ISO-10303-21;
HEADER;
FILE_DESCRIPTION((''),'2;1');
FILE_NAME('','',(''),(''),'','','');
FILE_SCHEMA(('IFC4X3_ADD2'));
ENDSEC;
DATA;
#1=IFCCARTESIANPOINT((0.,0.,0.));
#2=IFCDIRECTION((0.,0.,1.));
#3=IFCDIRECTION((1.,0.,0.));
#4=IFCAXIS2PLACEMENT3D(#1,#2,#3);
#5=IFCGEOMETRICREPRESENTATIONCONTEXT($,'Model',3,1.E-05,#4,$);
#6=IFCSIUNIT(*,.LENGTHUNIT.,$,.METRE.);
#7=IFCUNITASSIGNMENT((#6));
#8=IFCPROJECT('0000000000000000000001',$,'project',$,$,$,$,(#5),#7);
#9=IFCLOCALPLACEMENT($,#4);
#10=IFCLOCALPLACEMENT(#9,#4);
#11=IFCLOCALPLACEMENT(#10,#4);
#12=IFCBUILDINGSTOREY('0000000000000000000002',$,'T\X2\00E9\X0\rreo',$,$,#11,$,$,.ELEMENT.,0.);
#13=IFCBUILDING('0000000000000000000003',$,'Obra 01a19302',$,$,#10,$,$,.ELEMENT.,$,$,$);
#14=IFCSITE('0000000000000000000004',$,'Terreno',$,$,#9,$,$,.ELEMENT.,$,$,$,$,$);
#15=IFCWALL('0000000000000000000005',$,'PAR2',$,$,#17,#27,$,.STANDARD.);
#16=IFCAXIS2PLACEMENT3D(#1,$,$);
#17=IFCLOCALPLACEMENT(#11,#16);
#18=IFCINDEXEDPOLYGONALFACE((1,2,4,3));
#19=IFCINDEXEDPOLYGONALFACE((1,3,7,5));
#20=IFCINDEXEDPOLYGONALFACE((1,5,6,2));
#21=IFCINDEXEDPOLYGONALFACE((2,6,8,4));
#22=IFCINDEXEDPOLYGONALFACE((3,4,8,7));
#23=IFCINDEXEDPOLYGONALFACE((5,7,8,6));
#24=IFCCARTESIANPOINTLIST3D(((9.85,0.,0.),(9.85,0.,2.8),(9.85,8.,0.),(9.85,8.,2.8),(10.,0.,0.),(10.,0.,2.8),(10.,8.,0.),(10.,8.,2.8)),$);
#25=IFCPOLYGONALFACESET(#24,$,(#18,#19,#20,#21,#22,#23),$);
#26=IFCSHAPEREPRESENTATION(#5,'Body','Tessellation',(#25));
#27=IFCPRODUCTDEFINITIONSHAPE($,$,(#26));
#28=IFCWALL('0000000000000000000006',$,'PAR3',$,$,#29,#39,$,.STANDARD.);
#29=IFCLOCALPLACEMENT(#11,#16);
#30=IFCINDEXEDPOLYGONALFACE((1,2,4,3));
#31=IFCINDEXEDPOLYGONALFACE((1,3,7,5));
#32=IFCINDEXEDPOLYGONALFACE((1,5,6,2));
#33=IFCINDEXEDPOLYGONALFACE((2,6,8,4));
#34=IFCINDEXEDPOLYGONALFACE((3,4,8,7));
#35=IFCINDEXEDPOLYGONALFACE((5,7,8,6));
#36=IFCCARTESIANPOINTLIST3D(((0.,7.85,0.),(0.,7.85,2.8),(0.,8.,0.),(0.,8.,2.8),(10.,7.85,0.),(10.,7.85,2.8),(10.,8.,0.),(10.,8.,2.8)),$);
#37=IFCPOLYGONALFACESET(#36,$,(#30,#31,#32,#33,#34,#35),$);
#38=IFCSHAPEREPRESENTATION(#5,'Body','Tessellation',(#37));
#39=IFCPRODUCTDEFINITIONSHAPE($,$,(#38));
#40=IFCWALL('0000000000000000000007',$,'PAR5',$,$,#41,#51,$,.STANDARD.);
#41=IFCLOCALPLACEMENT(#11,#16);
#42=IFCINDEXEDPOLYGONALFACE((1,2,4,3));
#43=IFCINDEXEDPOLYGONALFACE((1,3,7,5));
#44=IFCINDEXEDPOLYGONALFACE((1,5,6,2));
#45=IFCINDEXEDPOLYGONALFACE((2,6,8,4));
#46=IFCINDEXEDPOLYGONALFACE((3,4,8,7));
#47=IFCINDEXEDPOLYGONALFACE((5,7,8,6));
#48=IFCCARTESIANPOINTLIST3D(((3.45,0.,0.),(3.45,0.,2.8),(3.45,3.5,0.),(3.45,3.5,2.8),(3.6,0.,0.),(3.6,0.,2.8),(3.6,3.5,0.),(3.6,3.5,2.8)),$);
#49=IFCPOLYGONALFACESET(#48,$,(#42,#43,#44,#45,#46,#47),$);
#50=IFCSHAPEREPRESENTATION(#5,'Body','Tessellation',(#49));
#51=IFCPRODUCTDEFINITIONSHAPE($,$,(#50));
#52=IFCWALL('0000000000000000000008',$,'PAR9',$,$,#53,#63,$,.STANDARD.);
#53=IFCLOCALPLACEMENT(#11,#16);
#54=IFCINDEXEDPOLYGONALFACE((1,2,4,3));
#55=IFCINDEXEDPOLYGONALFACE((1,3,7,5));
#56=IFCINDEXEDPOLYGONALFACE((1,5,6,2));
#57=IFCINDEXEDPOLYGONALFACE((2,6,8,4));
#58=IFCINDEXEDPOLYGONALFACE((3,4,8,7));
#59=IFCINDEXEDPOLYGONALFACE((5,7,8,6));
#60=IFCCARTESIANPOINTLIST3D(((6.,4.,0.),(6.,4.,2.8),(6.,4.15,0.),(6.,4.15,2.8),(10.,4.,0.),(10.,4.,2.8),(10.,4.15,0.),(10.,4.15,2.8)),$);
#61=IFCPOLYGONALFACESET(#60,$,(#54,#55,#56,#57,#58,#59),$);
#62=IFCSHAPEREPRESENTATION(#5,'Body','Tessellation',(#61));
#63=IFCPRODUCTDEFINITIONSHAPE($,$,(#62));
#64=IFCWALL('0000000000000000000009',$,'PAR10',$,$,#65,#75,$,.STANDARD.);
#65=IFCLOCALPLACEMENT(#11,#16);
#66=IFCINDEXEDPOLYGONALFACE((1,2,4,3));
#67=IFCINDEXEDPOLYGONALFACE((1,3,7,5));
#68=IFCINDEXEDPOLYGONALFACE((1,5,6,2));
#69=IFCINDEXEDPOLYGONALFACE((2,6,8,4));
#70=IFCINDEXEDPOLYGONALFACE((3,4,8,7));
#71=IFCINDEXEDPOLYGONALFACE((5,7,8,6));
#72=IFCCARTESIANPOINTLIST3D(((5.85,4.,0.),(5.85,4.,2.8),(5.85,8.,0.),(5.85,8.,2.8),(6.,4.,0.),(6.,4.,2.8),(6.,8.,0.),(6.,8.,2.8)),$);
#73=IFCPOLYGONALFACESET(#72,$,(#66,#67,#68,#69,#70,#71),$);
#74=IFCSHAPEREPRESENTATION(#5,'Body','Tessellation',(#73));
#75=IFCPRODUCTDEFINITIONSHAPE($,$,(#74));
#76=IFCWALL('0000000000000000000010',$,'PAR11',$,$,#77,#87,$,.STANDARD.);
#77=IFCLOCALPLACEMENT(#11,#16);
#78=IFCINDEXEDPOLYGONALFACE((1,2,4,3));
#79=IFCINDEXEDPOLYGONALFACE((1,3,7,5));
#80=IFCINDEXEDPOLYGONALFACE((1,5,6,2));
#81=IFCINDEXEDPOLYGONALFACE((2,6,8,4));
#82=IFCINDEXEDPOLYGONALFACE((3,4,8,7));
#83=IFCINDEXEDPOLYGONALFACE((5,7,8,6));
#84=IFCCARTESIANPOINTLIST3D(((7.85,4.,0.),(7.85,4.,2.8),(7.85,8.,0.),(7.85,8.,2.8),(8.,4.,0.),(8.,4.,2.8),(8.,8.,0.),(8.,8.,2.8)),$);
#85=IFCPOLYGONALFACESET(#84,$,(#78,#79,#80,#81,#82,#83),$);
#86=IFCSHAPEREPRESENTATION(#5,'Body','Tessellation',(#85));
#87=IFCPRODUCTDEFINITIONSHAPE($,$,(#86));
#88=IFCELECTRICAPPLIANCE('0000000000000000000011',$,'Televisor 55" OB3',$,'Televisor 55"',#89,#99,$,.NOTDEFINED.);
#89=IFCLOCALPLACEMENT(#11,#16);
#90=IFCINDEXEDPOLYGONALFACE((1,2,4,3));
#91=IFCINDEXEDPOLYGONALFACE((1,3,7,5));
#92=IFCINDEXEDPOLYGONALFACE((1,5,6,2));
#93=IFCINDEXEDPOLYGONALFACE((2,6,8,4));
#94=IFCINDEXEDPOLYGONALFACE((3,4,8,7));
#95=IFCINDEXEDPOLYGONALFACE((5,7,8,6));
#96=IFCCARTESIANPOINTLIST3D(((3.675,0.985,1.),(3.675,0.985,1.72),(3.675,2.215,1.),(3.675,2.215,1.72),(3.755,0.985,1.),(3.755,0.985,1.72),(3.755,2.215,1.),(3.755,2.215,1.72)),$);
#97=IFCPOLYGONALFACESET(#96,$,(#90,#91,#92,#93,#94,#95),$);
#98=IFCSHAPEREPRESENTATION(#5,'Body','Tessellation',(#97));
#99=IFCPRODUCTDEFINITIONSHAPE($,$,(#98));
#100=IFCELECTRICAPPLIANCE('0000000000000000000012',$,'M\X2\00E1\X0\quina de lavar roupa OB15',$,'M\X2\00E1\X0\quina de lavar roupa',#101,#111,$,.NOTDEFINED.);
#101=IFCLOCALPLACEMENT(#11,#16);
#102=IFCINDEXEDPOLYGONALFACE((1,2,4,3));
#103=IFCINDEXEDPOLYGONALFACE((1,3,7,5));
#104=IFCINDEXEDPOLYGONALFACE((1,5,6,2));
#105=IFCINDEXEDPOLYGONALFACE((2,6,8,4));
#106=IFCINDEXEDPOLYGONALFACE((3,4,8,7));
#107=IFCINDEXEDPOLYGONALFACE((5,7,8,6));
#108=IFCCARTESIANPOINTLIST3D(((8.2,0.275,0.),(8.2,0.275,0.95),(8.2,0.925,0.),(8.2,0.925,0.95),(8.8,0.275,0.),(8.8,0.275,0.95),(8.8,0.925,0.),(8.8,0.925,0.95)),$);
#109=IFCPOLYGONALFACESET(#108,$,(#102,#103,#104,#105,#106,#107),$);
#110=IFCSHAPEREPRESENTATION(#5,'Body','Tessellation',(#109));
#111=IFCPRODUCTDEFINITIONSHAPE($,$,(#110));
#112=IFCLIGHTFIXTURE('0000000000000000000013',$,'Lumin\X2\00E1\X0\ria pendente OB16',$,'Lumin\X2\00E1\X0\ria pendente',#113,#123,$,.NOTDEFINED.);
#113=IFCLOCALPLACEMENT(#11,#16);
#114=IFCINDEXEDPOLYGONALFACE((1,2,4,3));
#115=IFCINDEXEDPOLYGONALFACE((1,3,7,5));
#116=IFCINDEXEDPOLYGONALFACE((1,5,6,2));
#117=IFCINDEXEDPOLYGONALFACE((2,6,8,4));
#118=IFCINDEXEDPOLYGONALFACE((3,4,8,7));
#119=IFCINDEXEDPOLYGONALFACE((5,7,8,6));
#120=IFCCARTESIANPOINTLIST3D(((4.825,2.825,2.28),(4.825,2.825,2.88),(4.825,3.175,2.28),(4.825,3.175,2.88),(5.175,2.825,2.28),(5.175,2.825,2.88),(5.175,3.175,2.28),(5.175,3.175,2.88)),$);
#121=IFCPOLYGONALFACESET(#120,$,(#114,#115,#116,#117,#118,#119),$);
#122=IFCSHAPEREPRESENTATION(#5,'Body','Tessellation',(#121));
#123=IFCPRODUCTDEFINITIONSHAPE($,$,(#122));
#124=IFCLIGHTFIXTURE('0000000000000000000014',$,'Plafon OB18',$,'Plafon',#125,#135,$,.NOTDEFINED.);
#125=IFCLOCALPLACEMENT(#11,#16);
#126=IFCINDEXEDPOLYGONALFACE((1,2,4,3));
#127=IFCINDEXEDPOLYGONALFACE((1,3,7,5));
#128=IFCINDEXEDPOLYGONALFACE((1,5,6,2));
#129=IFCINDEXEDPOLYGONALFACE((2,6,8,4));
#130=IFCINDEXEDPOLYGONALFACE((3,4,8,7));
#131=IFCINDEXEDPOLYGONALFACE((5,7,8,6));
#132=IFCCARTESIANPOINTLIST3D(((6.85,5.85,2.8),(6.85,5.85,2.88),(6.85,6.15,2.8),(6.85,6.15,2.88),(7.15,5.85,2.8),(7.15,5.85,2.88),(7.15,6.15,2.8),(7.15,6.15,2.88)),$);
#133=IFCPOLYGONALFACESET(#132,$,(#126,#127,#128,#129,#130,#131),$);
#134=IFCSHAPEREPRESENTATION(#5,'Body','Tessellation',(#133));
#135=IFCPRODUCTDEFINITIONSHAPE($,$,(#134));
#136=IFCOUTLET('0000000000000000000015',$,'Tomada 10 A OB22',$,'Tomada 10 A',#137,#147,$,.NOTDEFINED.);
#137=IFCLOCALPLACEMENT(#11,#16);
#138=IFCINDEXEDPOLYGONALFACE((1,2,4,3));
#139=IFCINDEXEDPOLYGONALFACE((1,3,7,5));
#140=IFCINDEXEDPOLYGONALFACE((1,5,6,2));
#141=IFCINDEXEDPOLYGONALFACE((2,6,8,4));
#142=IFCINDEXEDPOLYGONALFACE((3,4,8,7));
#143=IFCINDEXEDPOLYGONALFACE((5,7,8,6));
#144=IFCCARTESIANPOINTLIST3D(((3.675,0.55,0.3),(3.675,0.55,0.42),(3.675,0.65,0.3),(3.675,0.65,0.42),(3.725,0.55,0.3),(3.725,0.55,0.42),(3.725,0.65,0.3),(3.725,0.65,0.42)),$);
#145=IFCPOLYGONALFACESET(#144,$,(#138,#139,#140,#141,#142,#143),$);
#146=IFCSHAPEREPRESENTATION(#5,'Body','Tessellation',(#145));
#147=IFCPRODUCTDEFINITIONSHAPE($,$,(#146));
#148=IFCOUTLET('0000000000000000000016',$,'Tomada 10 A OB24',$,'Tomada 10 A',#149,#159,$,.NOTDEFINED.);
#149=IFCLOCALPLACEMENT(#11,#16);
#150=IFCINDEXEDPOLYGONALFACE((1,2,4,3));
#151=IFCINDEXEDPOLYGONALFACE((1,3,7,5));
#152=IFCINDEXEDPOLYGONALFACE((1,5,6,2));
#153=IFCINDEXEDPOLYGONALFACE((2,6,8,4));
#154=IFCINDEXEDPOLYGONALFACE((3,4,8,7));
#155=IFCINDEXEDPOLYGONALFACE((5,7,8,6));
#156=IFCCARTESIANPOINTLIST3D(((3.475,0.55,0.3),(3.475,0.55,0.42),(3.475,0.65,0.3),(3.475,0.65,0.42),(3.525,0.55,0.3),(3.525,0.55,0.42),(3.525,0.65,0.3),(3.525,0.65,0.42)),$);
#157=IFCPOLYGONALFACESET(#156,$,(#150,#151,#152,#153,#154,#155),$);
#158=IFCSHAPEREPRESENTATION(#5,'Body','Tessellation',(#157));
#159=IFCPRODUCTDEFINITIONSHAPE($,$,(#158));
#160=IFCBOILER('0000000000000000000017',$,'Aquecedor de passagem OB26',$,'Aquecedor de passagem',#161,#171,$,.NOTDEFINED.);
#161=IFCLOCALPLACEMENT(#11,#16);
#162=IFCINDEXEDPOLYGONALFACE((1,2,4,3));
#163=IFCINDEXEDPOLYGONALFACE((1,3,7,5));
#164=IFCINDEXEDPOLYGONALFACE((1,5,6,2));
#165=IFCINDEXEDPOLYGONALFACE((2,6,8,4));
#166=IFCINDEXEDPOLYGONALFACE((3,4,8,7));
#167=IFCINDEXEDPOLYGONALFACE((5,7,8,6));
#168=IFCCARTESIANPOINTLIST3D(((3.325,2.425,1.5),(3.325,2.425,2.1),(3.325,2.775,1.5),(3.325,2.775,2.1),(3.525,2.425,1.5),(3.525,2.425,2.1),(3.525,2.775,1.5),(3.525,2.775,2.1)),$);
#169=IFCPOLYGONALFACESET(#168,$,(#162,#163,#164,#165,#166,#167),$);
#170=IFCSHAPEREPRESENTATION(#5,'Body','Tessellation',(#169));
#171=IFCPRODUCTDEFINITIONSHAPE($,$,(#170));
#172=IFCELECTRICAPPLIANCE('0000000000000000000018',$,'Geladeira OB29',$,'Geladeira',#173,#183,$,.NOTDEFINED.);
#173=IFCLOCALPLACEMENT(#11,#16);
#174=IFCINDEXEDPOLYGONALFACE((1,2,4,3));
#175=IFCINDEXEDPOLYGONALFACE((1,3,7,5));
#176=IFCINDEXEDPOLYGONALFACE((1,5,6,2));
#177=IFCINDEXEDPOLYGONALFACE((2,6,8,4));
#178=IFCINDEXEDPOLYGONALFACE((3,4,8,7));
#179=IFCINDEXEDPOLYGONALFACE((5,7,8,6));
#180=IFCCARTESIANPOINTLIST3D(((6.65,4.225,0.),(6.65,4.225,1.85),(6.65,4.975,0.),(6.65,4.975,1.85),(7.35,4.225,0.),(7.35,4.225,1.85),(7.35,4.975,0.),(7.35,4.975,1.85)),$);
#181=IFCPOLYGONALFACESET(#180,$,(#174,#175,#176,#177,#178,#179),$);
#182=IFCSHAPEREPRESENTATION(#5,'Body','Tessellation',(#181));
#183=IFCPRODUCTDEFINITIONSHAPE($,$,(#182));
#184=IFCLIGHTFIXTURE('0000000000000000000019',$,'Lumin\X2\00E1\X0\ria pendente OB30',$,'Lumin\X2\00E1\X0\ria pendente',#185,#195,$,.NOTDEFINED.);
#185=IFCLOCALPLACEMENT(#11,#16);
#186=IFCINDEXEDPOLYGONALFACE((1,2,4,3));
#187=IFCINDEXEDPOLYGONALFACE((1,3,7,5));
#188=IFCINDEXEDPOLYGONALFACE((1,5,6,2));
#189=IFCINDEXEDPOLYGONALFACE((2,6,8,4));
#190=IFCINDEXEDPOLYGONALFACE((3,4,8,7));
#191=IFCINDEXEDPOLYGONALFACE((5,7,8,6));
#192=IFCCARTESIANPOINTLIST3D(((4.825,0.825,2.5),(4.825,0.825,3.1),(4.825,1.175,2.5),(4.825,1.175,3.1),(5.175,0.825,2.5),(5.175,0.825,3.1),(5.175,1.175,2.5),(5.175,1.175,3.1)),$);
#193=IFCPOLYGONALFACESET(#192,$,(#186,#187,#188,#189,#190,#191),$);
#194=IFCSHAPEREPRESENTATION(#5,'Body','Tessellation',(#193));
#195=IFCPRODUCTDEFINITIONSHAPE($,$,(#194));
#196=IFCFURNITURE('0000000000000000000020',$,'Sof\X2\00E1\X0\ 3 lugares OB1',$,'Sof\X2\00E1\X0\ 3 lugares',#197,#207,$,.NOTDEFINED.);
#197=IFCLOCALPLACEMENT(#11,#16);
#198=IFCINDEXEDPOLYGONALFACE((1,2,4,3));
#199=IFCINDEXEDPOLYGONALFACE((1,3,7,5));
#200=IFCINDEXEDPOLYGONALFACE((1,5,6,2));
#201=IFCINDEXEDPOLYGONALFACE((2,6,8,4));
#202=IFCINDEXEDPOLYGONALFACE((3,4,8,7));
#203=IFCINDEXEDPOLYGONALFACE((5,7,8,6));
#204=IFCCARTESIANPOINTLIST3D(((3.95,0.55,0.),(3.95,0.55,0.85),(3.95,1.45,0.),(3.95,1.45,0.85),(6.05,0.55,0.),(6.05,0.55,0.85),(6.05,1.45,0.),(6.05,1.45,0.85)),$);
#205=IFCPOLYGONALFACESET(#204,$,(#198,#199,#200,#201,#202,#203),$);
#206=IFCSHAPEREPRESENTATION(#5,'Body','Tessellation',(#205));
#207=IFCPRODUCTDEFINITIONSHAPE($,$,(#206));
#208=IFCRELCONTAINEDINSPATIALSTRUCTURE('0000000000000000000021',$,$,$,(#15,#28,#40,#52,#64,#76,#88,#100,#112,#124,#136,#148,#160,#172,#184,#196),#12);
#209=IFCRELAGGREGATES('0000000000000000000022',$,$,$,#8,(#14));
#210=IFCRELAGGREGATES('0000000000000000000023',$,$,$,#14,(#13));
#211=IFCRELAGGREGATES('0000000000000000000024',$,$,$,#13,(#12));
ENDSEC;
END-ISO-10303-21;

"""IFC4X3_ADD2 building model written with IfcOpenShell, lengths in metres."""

from ifc_helpers import new_model, si_unit, frame, frame_2d, origin_with_axes, place, context, project, spatial, rectangle, extrude, element, save


model = new_model("IFC4X3_ADD2")

# Units and contexts
model_context = context("Model", 3, precision=1e-05, world=origin_with_axes())
ifc_project = project(units=[si_unit("LENGTHUNIT", "METRE")], contexts=[model_context])

# Site, building, storey
site_placement = place(None, origin_with_axes())
site = spatial("IfcSite", under=ifc_project, at=site_placement, Name="Terreno", CompositionType="ELEMENT")
building_placement = place(site_placement, origin_with_axes())
building = spatial("IfcBuilding", under=site, at=building_placement, Name="Obra 01a19302", CompositionType="ELEMENT")
storey_placement = place(building_placement, origin_with_axes())
storey = spatial("IfcBuildingStorey", under=building, at=storey_placement, Name="Térreo", CompositionType="ELEMENT", Elevation=0.0)

# Walls
wall_1_placement = place(storey_placement, frame((10.0, 0.0, 0.0), z_axis=(0.0, 0.0, 1.0), x_axis=(0.0, 1.0, 0.0)))
element("IfcWall", 1, at=wall_1_placement, inside=storey, Name="PAR2", PredefinedType="STANDARD", context=model_context, shape_type="SweptSolid", body=[
    extrude(rectangle(XDim=8.0, YDim=0.15, at=frame_2d((4.0, 0.075))), origin_with_axes(), (0.0, 0.0, 1.0), 2.8),
])
wall_2_placement = place(storey_placement, frame((10.0, 8.0, 0.0), z_axis=(0.0, 0.0, 1.0), x_axis=(-1.0, 0.0, 0.0)))
element("IfcWall", 2, at=wall_2_placement, inside=storey, Name="PAR3", PredefinedType="STANDARD", context=model_context, shape_type="SweptSolid", body=[
    extrude(rectangle(XDim=10.0, YDim=0.15, at=frame_2d((5.0, 0.075))), origin_with_axes(), (0.0, 0.0, 1.0), 2.8),
])
wall_3_placement = place(storey_placement, frame((3.6, 0.0, 0.0), z_axis=(0.0, 0.0, 1.0), x_axis=(0.0, 1.0, 0.0)))
element("IfcWall", 3, at=wall_3_placement, inside=storey, Name="PAR5", PredefinedType="STANDARD", context=model_context, shape_type="SweptSolid", body=[
    extrude(rectangle(XDim=3.5, YDim=0.15, at=frame_2d((1.75, 0.075))), origin_with_axes(), (0.0, 0.0, 1.0), 2.8),
])
for number, where, z_axis, x_axis, name in (
    (4, (6.0, 4.0, 0.0), (0.0, 0.0, 1.0), (1.0, 0.0, 0.0), "PAR9"),
    (5, (6.0, 4.0, 0.0), (0.0, 0.0, 1.0), (0.0, 1.0, 0.0), "PAR10"),
    (6, (8.0, 4.0, 0.0), (0.0, 0.0, 1.0), (0.0, 1.0, 0.0), "PAR11"),
):
    element("IfcWall", number, at=place(storey_placement, frame(where, z_axis=z_axis, x_axis=x_axis)), inside=storey, Name=name, PredefinedType="STANDARD", context=model_context, shape_type="SweptSolid", body=[
        extrude(rectangle(XDim=4.0, YDim=0.15, at=frame_2d((2.0, 0.075))), origin_with_axes(), (0.0, 0.0, 1.0), 2.8),
    ])

# Electric appliances
electric_appliance_1_placement = place(storey_placement, frame((3.675, 2.215, 1.0), z_axis=(0.0, 0.0, 1.0), x_axis=(0.0, -1.0, 0.0)))
element("IfcElectricAppliance", 7, at=electric_appliance_1_placement, inside=storey, Name="Televisor 55\" OB3", ObjectType="Televisor 55\"", PredefinedType="NOTDEFINED", context=model_context, shape_type="SweptSolid", body=[
    extrude(rectangle(XDim=1.23, YDim=0.08, at=frame_2d((0.615, 0.04))), origin_with_axes(), (0.0, 0.0, 1.0), 0.72),
])
electric_appliance_2_placement = place(storey_placement, frame((8.2, 0.275, 0.0), z_axis=(0.0, 0.0, 1.0), x_axis=(1.0, 0.0, 0.0)))
element("IfcElectricAppliance", 8, at=electric_appliance_2_placement, inside=storey, Name="Máquina de lavar roupa OB15", ObjectType="Máquina de lavar roupa", PredefinedType="NOTDEFINED", context=model_context, shape_type="SweptSolid", body=[
    extrude(rectangle(XDim=0.6, YDim=0.65, at=frame_2d((0.3, 0.325))), origin_with_axes(), (0.0, 0.0, 1.0), 0.95),
])

# Light fixtures
light_fixture_1_placement = place(storey_placement, frame((4.825, 2.825, 2.28), z_axis=(0.0, 0.0, 1.0), x_axis=(1.0, 0.0, 0.0)))
element("IfcLightFixture", 9, at=light_fixture_1_placement, inside=storey, Name="Luminária pendente OB16", ObjectType="Luminária pendente", PredefinedType="NOTDEFINED", context=model_context, shape_type="SweptSolid", body=[
    extrude(rectangle(XDim=0.35, YDim=0.35, at=frame_2d((0.175, 0.175))), origin_with_axes(), (0.0, 0.0, 1.0), 0.6),
])
light_fixture_2_placement = place(storey_placement, frame((6.85, 5.85, 2.8), z_axis=(0.0, 0.0, 1.0), x_axis=(1.0, 0.0, 0.0)))
element("IfcLightFixture", 10, at=light_fixture_2_placement, inside=storey, Name="Plafon OB18", ObjectType="Plafon", PredefinedType="NOTDEFINED", context=model_context, shape_type="SweptSolid", body=[
    extrude(rectangle(XDim=0.3, YDim=0.3, at=frame_2d((0.15, 0.15))), origin_with_axes(), (0.0, 0.0, 1.0), 0.08),
])

# Outlets
for number, where, z_axis, x_axis, name in (
    (11, (3.675, 0.65, 0.3), (0.0, 0.0, 1.0), (0.0, -1.0, 0.0), "Tomada 10 A OB22"),
    (12, (3.525, 0.55, 0.3), (0.0, 0.0, 1.0), (0.0, 1.0, 0.0), "Tomada 10 A OB24"),
):
    element("IfcOutlet", number, at=place(storey_placement, frame(where, z_axis=z_axis, x_axis=x_axis)), inside=storey, Name=name, ObjectType="Tomada 10 A", PredefinedType="NOTDEFINED", context=model_context, shape_type="SweptSolid", body=[
        extrude(rectangle(XDim=0.1, YDim=0.05, at=frame_2d((0.05, 0.025))), origin_with_axes(), (0.0, 0.0, 1.0), 0.12),
    ])

# Boiler
boiler_placement = place(storey_placement, frame((3.525, 2.425, 1.5), z_axis=(0.0, 0.0, 1.0), x_axis=(0.0, 1.0, 0.0)))
element("IfcBoiler", 13, at=boiler_placement, inside=storey, Name="Aquecedor de passagem OB26", ObjectType="Aquecedor de passagem", PredefinedType="NOTDEFINED", context=model_context, shape_type="SweptSolid", body=[
    extrude(rectangle(XDim=0.35, YDim=0.2, at=frame_2d((0.175, 0.1))), origin_with_axes(), (0.0, 0.0, 1.0), 0.6),
])

# Electric appliance
electric_appliance_3_placement = place(storey_placement, frame((6.65, 4.225, 0.0), z_axis=(0.0, 0.0, 1.0), x_axis=(1.0, 0.0, 0.0)))
element("IfcElectricAppliance", 14, at=electric_appliance_3_placement, inside=storey, Name="Geladeira OB29", ObjectType="Geladeira", PredefinedType="NOTDEFINED", context=model_context, shape_type="SweptSolid", body=[
    extrude(rectangle(XDim=0.7, YDim=0.75, at=frame_2d((0.35, 0.375))), origin_with_axes(), (0.0, 0.0, 1.0), 1.85),
])

# Light fixture
light_fixture_3_placement = place(storey_placement, frame((4.825, 0.825, 2.5), z_axis=(0.0, 0.0, 1.0), x_axis=(1.0, 0.0, 0.0)))
element("IfcLightFixture", 15, at=light_fixture_3_placement, inside=storey, Name="Luminária pendente OB30", ObjectType="Luminária pendente", PredefinedType="NOTDEFINED", context=model_context, shape_type="SweptSolid", body=[
    extrude(rectangle(XDim=0.35, YDim=0.35, at=frame_2d((0.175, 0.175))), origin_with_axes(), (0.0, 0.0, 1.0), 0.6),
])

# Furniture
furniture_1_placement = place(storey_placement, frame((3.95, 0.55, 0.0), z_axis=(0.0, 0.0, 1.0), x_axis=(1.0, 0.0, 0.0)))
element("IfcFurniture", 16, at=furniture_1_placement, inside=storey, Name="Sofá 3 lugares OB1", ObjectType="Sofá 3 lugares", PredefinedType="NOTDEFINED", context=model_context, shape_type="SweptSolid", body=[
    extrude(rectangle(XDim=2.1, YDim=0.9, at=frame_2d((1.05, 0.45))), origin_with_axes(), (0.0, 0.0, 1.0), 0.85),
])

save(model, "model.ifc")
